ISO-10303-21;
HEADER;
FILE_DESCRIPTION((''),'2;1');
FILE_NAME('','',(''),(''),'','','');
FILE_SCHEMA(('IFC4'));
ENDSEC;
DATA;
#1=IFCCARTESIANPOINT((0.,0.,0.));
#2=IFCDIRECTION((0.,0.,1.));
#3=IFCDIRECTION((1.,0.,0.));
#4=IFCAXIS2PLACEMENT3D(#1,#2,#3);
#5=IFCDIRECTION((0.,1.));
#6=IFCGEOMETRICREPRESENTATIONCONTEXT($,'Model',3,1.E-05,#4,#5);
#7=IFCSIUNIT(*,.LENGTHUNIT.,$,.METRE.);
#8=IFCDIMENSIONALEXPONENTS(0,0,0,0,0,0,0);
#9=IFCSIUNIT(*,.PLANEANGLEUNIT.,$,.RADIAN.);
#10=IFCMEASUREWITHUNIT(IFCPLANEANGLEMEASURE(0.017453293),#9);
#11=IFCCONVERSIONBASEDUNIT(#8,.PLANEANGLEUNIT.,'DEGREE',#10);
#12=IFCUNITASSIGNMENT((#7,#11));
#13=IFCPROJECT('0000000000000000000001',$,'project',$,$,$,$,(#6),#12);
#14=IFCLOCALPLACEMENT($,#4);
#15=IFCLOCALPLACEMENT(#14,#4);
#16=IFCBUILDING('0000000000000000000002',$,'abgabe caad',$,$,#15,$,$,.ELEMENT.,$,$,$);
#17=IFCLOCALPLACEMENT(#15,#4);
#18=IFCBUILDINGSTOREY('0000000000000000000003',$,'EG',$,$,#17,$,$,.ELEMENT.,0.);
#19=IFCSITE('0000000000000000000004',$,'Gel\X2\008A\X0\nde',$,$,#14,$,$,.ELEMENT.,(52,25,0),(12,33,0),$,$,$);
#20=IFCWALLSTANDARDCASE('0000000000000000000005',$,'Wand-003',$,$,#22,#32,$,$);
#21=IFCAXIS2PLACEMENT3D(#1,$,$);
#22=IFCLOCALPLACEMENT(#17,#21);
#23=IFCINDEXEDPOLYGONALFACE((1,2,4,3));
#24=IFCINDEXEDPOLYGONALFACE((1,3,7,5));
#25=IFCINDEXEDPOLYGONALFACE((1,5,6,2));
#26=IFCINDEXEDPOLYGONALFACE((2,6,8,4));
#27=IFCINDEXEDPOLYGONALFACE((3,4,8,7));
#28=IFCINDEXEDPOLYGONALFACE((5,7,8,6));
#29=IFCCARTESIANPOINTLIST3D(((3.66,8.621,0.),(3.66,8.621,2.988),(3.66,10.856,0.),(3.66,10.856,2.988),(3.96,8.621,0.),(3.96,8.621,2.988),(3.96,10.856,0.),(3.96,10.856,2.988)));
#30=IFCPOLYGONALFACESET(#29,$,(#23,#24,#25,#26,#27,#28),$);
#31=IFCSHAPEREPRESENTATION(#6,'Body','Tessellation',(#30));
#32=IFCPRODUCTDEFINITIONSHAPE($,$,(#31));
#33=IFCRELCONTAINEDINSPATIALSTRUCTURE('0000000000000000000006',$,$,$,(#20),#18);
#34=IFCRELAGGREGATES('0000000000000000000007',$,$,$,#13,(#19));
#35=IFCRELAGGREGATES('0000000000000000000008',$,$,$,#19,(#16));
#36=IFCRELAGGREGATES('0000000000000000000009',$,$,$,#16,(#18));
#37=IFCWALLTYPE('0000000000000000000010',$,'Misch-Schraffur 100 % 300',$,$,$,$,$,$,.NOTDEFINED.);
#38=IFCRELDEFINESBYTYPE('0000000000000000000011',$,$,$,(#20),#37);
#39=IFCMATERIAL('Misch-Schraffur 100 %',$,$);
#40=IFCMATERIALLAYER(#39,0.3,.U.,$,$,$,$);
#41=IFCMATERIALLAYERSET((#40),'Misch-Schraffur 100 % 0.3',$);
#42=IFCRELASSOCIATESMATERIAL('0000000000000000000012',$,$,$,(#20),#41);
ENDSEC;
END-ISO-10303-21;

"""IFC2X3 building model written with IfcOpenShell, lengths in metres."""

from ifc_helpers import new_model, entity, si_unit, converted_unit, direction, frame, origin_with_axes, place, context, project, spatial, polyline, outline, extrude, material, layer, layer_set, layer_usage, type_object, element, save


model = new_model("IFC2X3")

# Units and contexts
model_context = context("Model", 3, precision=1e-05, world=origin_with_axes(), true_north=direction((0.0, 1.0)))
ifc_project = project(units=[si_unit("LENGTHUNIT", "METRE"), converted_unit("PLANEANGLEUNIT", "DEGREE", entity("IfcPlaneAngleMeasure", 0.017453293), si_unit("PLANEANGLEUNIT", "RADIAN"), dimensions=[0, 0, 0, 0, 0, 0, 0])], contexts=[model_context])

# Site, building, storey
site_placement = place(None, origin_with_axes())
site = spatial("IfcSite", under=ifc_project, at=site_placement, Name="Gel\u008ande", CompositionType="ELEMENT", RefLatitude=(52, 25, 0), RefLongitude=(12, 33, 0))
building_placement = place(site_placement, origin_with_axes())
building = spatial("IfcBuilding", under=site, at=building_placement, Name="abgabe caad", CompositionType="ELEMENT")
storey_placement = place(building_placement, origin_with_axes())
storey = spatial("IfcBuildingStorey", under=building, at=storey_placement, Name="EG", CompositionType="ELEMENT", Elevation=0.0)

# Wall
ifc_material_1 = material(Name="Misch-Schraffur 100 %")
ifc_layer_1 = layer(ifc_material_1, 0.3, ventilated="UNKNOWN")
ifc_layer_set_1 = layer_set([ifc_layer_1], Name="Misch-Schraffur 100 % 0.3")
ifc_layer_usage_1 = layer_usage(ifc_layer_set_1, "AXIS2", "NEGATIVE", 0.0)
wall_type_1 = type_object("IfcWallType", Name="Misch-Schraffur 100 % 300", PredefinedType="NOTDEFINED")
wall_1_placement = place(storey_placement, frame((3.66, 8.621, 0.0), z_axis=(0.0, 0.0, 1.0), x_axis=(0.0, 1.0, 0.0)))
element("IfcWallStandardCase", 1, at=wall_1_placement, inside=storey, type_object=wall_type_1, material=ifc_layer_usage_1, Name="Wand-003", context=model_context, shape_type="SweptSolid", body=[
    extrude(outline(polyline([(0.0, -0.3), (2.235, -0.3), (2.235, 0.0), (0.0, 0.0), (0.0, -0.3)])), origin_with_axes(), (0.0, 0.0, 1.0), 2.988),
])

save(model, "model.ifc")
